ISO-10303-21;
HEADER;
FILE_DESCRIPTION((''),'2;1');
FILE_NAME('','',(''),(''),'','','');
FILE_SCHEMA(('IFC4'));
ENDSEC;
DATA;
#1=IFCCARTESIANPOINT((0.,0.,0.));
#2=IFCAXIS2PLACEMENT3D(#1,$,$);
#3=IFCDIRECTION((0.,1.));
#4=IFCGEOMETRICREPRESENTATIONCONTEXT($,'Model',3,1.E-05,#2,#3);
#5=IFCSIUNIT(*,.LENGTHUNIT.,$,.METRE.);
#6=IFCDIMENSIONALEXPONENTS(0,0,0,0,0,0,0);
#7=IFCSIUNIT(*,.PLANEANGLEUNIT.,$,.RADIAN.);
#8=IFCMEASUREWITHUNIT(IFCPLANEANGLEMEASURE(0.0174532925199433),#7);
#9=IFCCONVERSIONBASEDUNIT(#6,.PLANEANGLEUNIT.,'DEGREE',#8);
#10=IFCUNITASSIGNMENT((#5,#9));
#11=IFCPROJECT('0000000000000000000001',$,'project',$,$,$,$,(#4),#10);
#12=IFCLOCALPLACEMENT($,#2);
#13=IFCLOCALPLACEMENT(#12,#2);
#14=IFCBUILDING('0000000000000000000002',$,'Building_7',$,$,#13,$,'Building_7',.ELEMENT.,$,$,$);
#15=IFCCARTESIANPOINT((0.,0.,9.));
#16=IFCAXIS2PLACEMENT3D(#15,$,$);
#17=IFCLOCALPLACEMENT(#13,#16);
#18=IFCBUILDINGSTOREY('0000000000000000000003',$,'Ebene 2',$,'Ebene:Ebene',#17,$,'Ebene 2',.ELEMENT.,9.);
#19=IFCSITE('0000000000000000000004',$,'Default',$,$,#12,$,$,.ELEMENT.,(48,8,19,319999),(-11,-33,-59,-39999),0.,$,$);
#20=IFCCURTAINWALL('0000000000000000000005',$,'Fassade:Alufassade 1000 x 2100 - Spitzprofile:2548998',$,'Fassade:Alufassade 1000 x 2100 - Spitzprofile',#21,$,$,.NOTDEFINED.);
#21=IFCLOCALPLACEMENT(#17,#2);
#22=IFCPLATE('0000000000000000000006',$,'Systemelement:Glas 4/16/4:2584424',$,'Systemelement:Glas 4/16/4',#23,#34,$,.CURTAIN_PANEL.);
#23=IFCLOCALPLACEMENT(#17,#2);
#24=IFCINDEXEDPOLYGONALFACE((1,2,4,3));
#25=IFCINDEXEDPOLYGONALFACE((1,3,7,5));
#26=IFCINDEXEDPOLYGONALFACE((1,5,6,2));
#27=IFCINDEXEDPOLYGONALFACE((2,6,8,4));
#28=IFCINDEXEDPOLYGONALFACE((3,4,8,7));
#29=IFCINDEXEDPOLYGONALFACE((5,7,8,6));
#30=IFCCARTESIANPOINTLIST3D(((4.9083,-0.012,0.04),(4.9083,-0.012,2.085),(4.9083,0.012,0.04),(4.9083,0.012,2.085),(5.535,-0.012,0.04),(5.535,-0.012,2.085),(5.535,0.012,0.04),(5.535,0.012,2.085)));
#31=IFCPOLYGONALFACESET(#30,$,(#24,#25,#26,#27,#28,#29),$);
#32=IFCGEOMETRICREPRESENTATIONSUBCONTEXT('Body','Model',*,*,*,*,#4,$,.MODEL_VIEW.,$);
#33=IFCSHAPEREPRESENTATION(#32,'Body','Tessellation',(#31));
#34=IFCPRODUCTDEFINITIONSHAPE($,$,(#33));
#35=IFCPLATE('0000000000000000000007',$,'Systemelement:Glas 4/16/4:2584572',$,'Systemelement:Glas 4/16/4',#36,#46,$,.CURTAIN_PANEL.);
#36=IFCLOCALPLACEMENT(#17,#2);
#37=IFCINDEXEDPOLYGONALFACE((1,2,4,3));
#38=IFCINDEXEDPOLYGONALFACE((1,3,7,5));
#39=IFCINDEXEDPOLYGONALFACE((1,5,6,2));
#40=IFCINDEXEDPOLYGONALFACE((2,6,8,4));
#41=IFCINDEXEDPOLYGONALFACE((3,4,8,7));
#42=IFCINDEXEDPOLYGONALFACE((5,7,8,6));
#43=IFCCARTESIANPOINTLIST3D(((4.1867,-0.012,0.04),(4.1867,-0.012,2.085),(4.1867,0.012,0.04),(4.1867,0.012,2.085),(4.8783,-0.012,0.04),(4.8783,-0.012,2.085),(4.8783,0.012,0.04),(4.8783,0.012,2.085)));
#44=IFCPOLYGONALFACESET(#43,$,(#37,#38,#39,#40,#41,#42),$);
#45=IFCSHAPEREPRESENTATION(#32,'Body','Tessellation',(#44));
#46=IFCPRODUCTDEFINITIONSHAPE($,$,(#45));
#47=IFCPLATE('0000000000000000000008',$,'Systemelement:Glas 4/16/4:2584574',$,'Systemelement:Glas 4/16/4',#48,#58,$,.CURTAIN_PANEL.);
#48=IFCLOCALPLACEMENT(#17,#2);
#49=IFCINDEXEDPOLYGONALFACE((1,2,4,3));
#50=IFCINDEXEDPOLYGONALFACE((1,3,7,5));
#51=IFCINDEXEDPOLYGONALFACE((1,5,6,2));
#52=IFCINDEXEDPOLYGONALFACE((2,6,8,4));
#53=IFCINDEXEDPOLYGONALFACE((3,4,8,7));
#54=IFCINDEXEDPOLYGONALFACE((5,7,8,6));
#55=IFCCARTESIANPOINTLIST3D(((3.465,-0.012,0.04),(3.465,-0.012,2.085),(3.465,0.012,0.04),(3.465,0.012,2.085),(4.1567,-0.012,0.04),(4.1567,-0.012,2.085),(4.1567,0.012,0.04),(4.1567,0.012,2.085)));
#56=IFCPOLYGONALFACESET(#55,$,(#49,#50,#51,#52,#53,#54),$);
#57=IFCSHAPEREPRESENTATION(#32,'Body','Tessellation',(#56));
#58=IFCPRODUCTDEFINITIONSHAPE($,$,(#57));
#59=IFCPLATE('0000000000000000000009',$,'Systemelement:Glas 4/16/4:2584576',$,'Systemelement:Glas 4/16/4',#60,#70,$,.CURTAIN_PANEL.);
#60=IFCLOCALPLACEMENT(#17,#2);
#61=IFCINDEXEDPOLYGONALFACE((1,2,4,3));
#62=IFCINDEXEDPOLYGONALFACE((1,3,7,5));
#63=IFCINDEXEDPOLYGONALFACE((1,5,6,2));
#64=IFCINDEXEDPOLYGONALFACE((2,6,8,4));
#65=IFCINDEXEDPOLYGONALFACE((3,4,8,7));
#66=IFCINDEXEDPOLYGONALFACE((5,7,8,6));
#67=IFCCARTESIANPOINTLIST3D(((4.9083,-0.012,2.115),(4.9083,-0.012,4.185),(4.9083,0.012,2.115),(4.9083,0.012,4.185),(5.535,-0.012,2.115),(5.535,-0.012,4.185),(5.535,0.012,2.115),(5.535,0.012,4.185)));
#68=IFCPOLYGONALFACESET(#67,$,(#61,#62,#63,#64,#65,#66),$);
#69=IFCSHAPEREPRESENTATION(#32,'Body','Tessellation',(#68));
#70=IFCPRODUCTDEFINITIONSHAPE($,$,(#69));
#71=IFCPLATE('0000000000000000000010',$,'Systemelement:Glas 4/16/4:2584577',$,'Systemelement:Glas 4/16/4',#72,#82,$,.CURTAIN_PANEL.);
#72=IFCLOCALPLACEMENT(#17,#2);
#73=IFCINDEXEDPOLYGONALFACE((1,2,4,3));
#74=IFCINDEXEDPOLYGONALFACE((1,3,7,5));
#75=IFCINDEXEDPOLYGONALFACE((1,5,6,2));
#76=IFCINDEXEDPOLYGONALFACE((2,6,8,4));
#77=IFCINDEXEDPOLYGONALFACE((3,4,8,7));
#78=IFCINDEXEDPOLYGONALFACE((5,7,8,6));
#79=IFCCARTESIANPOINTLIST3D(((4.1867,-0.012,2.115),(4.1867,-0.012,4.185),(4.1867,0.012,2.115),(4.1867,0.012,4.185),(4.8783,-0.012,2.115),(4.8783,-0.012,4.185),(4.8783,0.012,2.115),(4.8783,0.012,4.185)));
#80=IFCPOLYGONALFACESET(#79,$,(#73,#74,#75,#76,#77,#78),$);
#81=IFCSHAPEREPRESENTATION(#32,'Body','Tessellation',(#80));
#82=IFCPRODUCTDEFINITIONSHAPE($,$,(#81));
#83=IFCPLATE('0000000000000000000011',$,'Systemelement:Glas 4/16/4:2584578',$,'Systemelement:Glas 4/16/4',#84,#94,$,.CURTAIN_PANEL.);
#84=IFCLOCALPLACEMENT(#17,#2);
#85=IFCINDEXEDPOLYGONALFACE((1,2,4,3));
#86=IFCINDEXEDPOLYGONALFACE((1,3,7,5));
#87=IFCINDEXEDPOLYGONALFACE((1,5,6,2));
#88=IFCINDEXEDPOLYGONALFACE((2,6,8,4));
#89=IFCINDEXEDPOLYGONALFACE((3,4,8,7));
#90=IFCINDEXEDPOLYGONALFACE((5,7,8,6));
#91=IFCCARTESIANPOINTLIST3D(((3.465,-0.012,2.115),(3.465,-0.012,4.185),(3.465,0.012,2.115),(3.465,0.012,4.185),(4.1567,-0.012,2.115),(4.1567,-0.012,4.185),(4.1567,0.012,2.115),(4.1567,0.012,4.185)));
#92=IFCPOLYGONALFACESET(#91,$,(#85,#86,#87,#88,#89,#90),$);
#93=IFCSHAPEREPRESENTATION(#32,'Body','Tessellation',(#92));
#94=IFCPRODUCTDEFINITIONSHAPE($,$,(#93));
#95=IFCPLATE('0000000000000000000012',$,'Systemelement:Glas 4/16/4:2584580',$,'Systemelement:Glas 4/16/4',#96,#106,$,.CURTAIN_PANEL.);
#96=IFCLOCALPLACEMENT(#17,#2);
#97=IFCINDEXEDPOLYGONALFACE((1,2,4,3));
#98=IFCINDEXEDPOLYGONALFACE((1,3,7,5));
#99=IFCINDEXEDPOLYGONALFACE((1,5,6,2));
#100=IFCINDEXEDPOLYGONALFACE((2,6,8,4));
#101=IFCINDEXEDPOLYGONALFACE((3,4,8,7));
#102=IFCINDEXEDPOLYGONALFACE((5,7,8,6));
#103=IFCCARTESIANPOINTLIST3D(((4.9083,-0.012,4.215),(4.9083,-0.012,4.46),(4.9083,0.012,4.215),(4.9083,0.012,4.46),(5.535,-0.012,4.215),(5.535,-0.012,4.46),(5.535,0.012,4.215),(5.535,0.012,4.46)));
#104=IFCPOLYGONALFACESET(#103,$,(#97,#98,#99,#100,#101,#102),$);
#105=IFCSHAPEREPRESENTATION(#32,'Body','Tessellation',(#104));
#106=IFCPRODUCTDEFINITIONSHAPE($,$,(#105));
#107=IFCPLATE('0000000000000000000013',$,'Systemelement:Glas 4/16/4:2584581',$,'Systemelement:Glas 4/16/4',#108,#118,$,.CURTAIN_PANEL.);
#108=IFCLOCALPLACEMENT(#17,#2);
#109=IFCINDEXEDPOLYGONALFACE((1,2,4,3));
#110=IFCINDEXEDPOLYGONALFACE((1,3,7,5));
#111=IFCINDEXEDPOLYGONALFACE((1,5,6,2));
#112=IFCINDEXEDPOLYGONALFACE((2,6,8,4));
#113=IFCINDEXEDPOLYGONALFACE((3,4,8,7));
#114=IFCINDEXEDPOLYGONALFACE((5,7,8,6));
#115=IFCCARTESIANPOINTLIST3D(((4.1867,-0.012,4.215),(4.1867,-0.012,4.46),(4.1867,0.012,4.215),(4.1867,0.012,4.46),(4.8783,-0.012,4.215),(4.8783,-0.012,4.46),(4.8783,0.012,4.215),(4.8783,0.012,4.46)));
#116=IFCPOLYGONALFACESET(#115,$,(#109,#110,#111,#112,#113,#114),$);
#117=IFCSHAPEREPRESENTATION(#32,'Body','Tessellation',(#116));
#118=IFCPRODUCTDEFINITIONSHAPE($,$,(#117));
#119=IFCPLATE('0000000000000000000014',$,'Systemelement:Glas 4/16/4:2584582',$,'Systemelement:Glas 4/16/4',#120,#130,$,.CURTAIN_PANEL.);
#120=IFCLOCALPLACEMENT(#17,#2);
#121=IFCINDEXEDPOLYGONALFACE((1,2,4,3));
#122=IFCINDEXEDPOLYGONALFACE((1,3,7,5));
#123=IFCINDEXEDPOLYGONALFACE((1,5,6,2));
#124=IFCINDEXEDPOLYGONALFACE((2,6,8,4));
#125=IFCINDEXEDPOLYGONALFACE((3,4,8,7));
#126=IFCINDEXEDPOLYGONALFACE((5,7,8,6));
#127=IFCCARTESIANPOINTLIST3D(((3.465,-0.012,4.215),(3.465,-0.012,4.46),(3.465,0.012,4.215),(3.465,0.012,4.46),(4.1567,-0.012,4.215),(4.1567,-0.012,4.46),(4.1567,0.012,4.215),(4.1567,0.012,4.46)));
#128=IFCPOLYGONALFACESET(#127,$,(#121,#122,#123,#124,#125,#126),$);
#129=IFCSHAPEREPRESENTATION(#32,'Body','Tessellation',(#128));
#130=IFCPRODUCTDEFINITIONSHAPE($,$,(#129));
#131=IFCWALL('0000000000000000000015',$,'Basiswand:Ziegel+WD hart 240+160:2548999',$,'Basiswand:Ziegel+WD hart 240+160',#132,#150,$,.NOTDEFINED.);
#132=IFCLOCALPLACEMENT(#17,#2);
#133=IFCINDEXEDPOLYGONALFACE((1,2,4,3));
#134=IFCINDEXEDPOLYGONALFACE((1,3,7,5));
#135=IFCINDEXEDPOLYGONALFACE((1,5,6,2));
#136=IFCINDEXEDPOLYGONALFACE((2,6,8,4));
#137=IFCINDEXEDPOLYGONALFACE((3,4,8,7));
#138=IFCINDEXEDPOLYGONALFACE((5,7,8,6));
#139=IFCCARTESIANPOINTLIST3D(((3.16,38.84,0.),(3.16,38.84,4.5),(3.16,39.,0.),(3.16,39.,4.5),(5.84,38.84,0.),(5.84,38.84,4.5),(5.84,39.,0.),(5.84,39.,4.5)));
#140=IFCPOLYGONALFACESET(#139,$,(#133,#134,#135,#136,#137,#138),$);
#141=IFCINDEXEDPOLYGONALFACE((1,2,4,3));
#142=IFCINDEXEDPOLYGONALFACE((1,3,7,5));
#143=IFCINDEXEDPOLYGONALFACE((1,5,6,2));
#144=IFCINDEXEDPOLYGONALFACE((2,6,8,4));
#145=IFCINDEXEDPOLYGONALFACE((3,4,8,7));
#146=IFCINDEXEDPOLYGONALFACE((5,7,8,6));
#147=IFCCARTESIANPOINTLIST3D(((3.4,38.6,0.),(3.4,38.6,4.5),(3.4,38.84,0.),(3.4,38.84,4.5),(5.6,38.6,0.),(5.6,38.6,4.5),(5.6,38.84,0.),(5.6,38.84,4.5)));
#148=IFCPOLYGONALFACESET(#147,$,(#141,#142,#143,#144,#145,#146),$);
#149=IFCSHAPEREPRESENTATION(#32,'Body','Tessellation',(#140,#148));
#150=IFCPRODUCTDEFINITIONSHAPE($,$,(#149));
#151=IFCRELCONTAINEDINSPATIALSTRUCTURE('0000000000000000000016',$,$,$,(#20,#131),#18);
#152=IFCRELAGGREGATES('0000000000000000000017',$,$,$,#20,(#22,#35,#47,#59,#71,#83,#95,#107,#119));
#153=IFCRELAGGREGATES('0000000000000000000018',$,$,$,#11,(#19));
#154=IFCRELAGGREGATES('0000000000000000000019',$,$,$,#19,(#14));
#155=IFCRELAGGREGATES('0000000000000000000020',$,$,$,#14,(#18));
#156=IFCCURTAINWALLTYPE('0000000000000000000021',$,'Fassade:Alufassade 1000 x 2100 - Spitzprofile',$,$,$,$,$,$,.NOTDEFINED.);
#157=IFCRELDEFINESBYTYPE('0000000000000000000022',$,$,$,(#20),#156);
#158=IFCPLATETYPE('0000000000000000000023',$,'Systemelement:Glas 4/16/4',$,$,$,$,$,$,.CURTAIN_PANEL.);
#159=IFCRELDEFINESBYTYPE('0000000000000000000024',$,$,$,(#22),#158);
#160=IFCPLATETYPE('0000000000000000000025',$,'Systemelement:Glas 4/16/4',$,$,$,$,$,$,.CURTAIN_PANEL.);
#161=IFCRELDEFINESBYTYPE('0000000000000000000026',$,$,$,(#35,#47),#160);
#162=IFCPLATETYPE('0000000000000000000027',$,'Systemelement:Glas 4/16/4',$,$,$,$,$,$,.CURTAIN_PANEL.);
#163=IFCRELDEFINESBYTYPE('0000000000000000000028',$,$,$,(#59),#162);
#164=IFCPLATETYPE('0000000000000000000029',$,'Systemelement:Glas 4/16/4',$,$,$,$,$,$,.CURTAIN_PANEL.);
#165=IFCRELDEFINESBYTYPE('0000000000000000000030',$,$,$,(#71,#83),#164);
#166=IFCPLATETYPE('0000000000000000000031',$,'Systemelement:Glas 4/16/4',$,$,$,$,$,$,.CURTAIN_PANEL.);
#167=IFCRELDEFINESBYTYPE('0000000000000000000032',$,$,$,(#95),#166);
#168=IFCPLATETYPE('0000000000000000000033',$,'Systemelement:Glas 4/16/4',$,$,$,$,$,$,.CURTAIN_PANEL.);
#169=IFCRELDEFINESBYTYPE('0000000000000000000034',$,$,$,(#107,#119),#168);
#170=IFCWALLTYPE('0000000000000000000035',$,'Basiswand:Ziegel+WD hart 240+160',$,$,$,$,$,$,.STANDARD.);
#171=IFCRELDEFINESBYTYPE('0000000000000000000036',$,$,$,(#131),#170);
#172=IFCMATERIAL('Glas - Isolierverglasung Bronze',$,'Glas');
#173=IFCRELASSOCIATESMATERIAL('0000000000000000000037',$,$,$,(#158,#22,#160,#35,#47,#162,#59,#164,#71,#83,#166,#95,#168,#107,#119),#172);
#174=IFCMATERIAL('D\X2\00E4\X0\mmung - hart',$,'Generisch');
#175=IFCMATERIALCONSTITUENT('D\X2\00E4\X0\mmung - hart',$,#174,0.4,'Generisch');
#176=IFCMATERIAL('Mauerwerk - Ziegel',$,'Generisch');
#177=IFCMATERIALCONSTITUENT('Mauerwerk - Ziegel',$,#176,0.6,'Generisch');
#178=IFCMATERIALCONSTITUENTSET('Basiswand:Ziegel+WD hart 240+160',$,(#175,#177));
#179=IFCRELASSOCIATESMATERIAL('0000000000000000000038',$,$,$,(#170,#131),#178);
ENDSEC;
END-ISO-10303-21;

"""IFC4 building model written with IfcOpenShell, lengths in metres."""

from ifc_helpers import new_model, entity, si_unit, converted_unit, direction, frame, origin, place, context, subcontext, project, spatial, indexed_curve, outline, extrude, source, transform, mapped, material, constituent, constituent_set, type_object, type_shapes, element, aggregate, save


model = new_model("IFC4")

# Units and contexts
model_context = context("Model", 3, precision=1e-05, world=origin(), true_north=direction((0.0, 1.0)))
body_context = subcontext(model_context, "Body", "Model", "MODEL_VIEW")
ifc_project = project(units=[si_unit("LENGTHUNIT", "METRE"), converted_unit("PLANEANGLEUNIT", "DEGREE", entity("IfcPlaneAngleMeasure", 0.0174532925199433), si_unit("PLANEANGLEUNIT", "RADIAN"), dimensions=[0, 0, 0, 0, 0, 0, 0])], contexts=[model_context])

# Site, building, storey
site_placement = place(None, origin())
site = spatial("IfcSite", under=ifc_project, at=site_placement, Name="Default", CompositionType="ELEMENT", RefLatitude=(48, 8, 19, 319999), RefLongitude=(-11, -33, -59, -39999), RefElevation=0.0)
building_placement = place(site_placement, origin())
building = spatial("IfcBuilding", under=site, at=building_placement, Name="Building_7", LongName="Building_7", CompositionType="ELEMENT")
storey_placement = place(building_placement, frame((0.0, 0.0, 9.0)))
storey = spatial("IfcBuildingStorey", under=building, at=storey_placement, Name="Ebene 2", ObjectType="Ebene:Ebene", LongName="Ebene 2", CompositionType="ELEMENT", Elevation=9.0)

# Curtain wall
curtain_wall_type = type_object("IfcCurtainWallType", Name="Fassade:Alufassade 1000 x 2100 - Spitzprofile", PredefinedType="NOTDEFINED")
curtain_wall_placement = place(storey_placement, frame((0.0, 0.0, -9.0)))
curtain_wall = element("IfcCurtainWall", 1, at=curtain_wall_placement, inside=storey, type_object=curtain_wall_type, Name="Fassade:Alufassade 1000 x 2100 - Spitzprofile:2548998", ObjectType="Fassade:Alufassade 1000 x 2100 - Spitzprofile", PredefinedType="NOTDEFINED")

# Plates
ifc_material_1 = material(Name="Glas - Isolierverglasung Bronze", Category="Glas")
plate_type_1 = type_object("IfcPlateType", Name="Systemelement:Glas 4/16/4", PredefinedType="CURTAIN_PANEL", material=ifc_material_1)
shared_shape_1 = source(origin(), body_context, "Body", "SweptSolid", [
    extrude(outline(indexed_curve([(-0.012, -0.3133), (0.012, -0.3133), (0.012, 0.3133), (-0.012, 0.3133), (-0.012, -0.3133)], self_intersect=False)), frame((0.0, 0.0, 0.0), z_axis=(0.0, 0.0, 1.0), x_axis=(0.0, 1.0, 0.0)), (0.0, 0.0, 1.0), 2.045),
])
type_shapes(plate_type_1, [shared_shape_1])
plate_1_placement = place(curtain_wall_placement, frame((5.2217, 0.0, 9.04), z_axis=(0.0, 0.0, 1.0), x_axis=(-1.0, 0.0, 0.0)))
plate_1 = element("IfcPlate", 2, at=plate_1_placement, type_object=plate_type_1, material=ifc_material_1, Name="Systemelement:Glas 4/16/4:2584424", ObjectType="Systemelement:Glas 4/16/4", PredefinedType="CURTAIN_PANEL", context=body_context, shape_type="MappedRepresentation", body=[
    mapped(shared_shape_1, transform((0.0, 0.0, 0.0), scale=1.0)),
])
plate_type_2 = type_object("IfcPlateType", Name="Systemelement:Glas 4/16/4", PredefinedType="CURTAIN_PANEL", material=ifc_material_1)
shared_shape_2 = source(origin(), body_context, "Body", "SweptSolid", [
    extrude(outline(indexed_curve([(-0.012, -0.3458), (0.012, -0.3458), (0.012, 0.3458), (-0.012, 0.3458), (-0.012, -0.3458)], self_intersect=False)), frame((0.0, 0.0, 0.0), z_axis=(0.0, 0.0, 1.0), x_axis=(0.0, 1.0, 0.0)), (0.0, 0.0, 1.0), 2.045),
])
type_shapes(plate_type_2, [shared_shape_2])
plate_2_placement = place(curtain_wall_placement, frame((4.5325, 0.0, 9.04), z_axis=(0.0, 0.0, 1.0), x_axis=(-1.0, 0.0, 0.0)))
plate_2 = element("IfcPlate", 3, at=plate_2_placement, type_object=plate_type_2, material=ifc_material_1, Name="Systemelement:Glas 4/16/4:2584572", ObjectType="Systemelement:Glas 4/16/4", PredefinedType="CURTAIN_PANEL", context=body_context, shape_type="MappedRepresentation", body=[
    mapped(shared_shape_2, transform((0.0, 0.0, 0.0), scale=1.0)),
])
plate_3_placement = place(curtain_wall_placement, frame((3.8108, 0.0, 9.04), z_axis=(0.0, 0.0, 1.0), x_axis=(-1.0, 0.0, 0.0)))
plate_3 = element("IfcPlate", 4, at=plate_3_placement, type_object=plate_type_2, material=ifc_material_1, Name="Systemelement:Glas 4/16/4:2584574", ObjectType="Systemelement:Glas 4/16/4", PredefinedType="CURTAIN_PANEL", context=body_context, shape_type="MappedRepresentation", body=[
    mapped(shared_shape_2, transform((0.0, 0.0, 0.0), scale=1.0)),
])
plate_type_3 = type_object("IfcPlateType", Name="Systemelement:Glas 4/16/4", PredefinedType="CURTAIN_PANEL", material=ifc_material_1)
shared_shape_3 = source(origin(), body_context, "Body", "SweptSolid", [
    extrude(outline(indexed_curve([(-0.012, -0.3133), (0.012, -0.3133), (0.012, 0.3133), (-0.012, 0.3133), (-0.012, -0.3133)], self_intersect=False)), frame((0.0, 0.0, 0.0), z_axis=(0.0, 0.0, 1.0), x_axis=(0.0, 1.0, 0.0)), (0.0, 0.0, 1.0), 2.07),
])
type_shapes(plate_type_3, [shared_shape_3])
plate_4_placement = place(curtain_wall_placement, frame((5.2217, 0.0, 11.115), z_axis=(0.0, 0.0, 1.0), x_axis=(-1.0, 0.0, 0.0)))
plate_4 = element("IfcPlate", 5, at=plate_4_placement, type_object=plate_type_3, material=ifc_material_1, Name="Systemelement:Glas 4/16/4:2584576", ObjectType="Systemelement:Glas 4/16/4", PredefinedType="CURTAIN_PANEL", context=body_context, shape_type="MappedRepresentation", body=[
    mapped(shared_shape_3, transform((0.0, 0.0, 0.0), scale=1.0)),
])
plate_type_4 = type_object("IfcPlateType", Name="Systemelement:Glas 4/16/4", PredefinedType="CURTAIN_PANEL", material=ifc_material_1)
shared_shape_4 = source(origin(), body_context, "Body", "SweptSolid", [
    extrude(outline(indexed_curve([(-0.012, -0.3458), (0.012, -0.3458), (0.012, 0.3458), (-0.012, 0.3458), (-0.012, -0.3458)], self_intersect=False)), frame((0.0, 0.0, 0.0), z_axis=(0.0, 0.0, 1.0), x_axis=(0.0, 1.0, 0.0)), (0.0, 0.0, 1.0), 2.07),
])
type_shapes(plate_type_4, [shared_shape_4])
plate_5_placement = place(curtain_wall_placement, frame((4.5325, 0.0, 11.115), z_axis=(0.0, 0.0, 1.0), x_axis=(-1.0, 0.0, 0.0)))
plate_5 = element("IfcPlate", 6, at=plate_5_placement, type_object=plate_type_4, material=ifc_material_1, Name="Systemelement:Glas 4/16/4:2584577", ObjectType="Systemelement:Glas 4/16/4", PredefinedType="CURTAIN_PANEL", context=body_context, shape_type="MappedRepresentation", body=[
    mapped(shared_shape_4, transform((0.0, 0.0, 0.0), scale=1.0)),
])
plate_6_placement = place(curtain_wall_placement, frame((3.8108, 0.0, 11.115), z_axis=(0.0, 0.0, 1.0), x_axis=(-1.0, 0.0, 0.0)))
plate_6 = element("IfcPlate", 7, at=plate_6_placement, type_object=plate_type_4, material=ifc_material_1, Name="Systemelement:Glas 4/16/4:2584578", ObjectType="Systemelement:Glas 4/16/4", PredefinedType="CURTAIN_PANEL", context=body_context, shape_type="MappedRepresentation", body=[
    mapped(shared_shape_4, transform((0.0, 0.0, 0.0), scale=1.0)),
])
plate_type_5 = type_object("IfcPlateType", Name="Systemelement:Glas 4/16/4", PredefinedType="CURTAIN_PANEL", material=ifc_material_1)
shared_shape_5 = source(origin(), body_context, "Body", "SweptSolid", [
    extrude(outline(indexed_curve([(-0.012, -0.3133), (0.012, -0.3133), (0.012, 0.3133), (-0.012, 0.3133), (-0.012, -0.3133)], self_intersect=False)), frame((0.0, 0.0, 0.0), z_axis=(0.0, 0.0, 1.0), x_axis=(0.0, 1.0, 0.0)), (0.0, 0.0, 1.0), 0.245),
])
type_shapes(plate_type_5, [shared_shape_5])
plate_7_placement = place(curtain_wall_placement, frame((5.2217, 0.0, 13.215), z_axis=(0.0, 0.0, 1.0), x_axis=(-1.0, 0.0, 0.0)))
plate_7 = element("IfcPlate", 8, at=plate_7_placement, type_object=plate_type_5, material=ifc_material_1, Name="Systemelement:Glas 4/16/4:2584580", ObjectType="Systemelement:Glas 4/16/4", PredefinedType="CURTAIN_PANEL", context=body_context, shape_type="MappedRepresentation", body=[
    mapped(shared_shape_5, transform((0.0, 0.0, 0.0), scale=1.0)),
])
plate_type_6 = type_object("IfcPlateType", Name="Systemelement:Glas 4/16/4", PredefinedType="CURTAIN_PANEL", material=ifc_material_1)
shared_shape_6 = source(origin(), body_context, "Body", "SweptSolid", [
    extrude(outline(indexed_curve([(-0.012, -0.3458), (0.012, -0.3458), (0.012, 0.3458), (-0.012, 0.3458), (-0.012, -0.3458)], self_intersect=False)), frame((0.0, 0.0, 0.0), z_axis=(0.0, 0.0, 1.0), x_axis=(0.0, 1.0, 0.0)), (0.0, 0.0, 1.0), 0.245),
])
type_shapes(plate_type_6, [shared_shape_6])
plate_8_placement = place(curtain_wall_placement, frame((4.5325, 0.0, 13.215), z_axis=(0.0, 0.0, 1.0), x_axis=(-1.0, 0.0, 0.0)))
plate_8 = element("IfcPlate", 9, at=plate_8_placement, type_object=plate_type_6, material=ifc_material_1, Name="Systemelement:Glas 4/16/4:2584581", ObjectType="Systemelement:Glas 4/16/4", PredefinedType="CURTAIN_PANEL", context=body_context, shape_type="MappedRepresentation", body=[
    mapped(shared_shape_6, transform((0.0, 0.0, 0.0), scale=1.0)),
])
plate_9_placement = place(curtain_wall_placement, frame((3.8108, 0.0, 13.215), z_axis=(0.0, 0.0, 1.0), x_axis=(-1.0, 0.0, 0.0)))
plate_9 = element("IfcPlate", 10, at=plate_9_placement, type_object=plate_type_6, material=ifc_material_1, Name="Systemelement:Glas 4/16/4:2584582", ObjectType="Systemelement:Glas 4/16/4", PredefinedType="CURTAIN_PANEL", context=body_context, shape_type="MappedRepresentation", body=[
    mapped(shared_shape_6, transform((0.0, 0.0, 0.0), scale=1.0)),
])
aggregate(curtain_wall, [plate_1, plate_2, plate_3, plate_4, plate_5, plate_6, plate_7, plate_8, plate_9])

# Wall
ifc_material_2 = material(Name="Dämmung - hart", Category="Generisch")
ifc_constituent_1 = constituent(ifc_material_2, Name="Dämmung - hart", Category="Generisch", fraction=0.4)
ifc_material_3 = material(Name="Mauerwerk - Ziegel", Category="Generisch")
ifc_constituent_2 = constituent(ifc_material_3, Name="Mauerwerk - Ziegel", Category="Generisch", fraction=0.6)
ifc_constituent_set = constituent_set(constituents=[ifc_constituent_1, ifc_constituent_2], Name="Basiswand:Ziegel+WD hart 240+160")
wall_type = type_object("IfcWallType", Name="Basiswand:Ziegel+WD hart 240+160", PredefinedType="STANDARD", material=ifc_constituent_set)
wall_placement = place(storey_placement, frame((3.4, 38.8, 0.0)))
element("IfcWall", 11, at=wall_placement, inside=storey, type_object=wall_type, material=ifc_constituent_set, Name="Basiswand:Ziegel+WD hart 240+160:2548999", ObjectType="Basiswand:Ziegel+WD hart 240+160", PredefinedType="NOTDEFINED", context=body_context, shape_type="SweptSolid", body=[
    extrude(outline(indexed_curve([(-0.08, -1.34), (0.08, -1.34), (0.08, 1.34), (-0.08, 1.34), (-0.08, -1.34)], self_intersect=False)), frame((1.1, 0.12, 0.0), z_axis=(0.0, 0.0, 1.0), x_axis=(0.0, -1.0, 0.0)), (0.0, 0.0, 1.0), 4.5),
    extrude(outline(indexed_curve([(-0.12, -1.1), (0.12, -1.1), (0.12, 1.1), (-0.12, 1.1), (-0.12, -1.1)], self_intersect=False)), frame((1.1, -0.08, 0.0), z_axis=(0.0, 0.0, 1.0), x_axis=(0.0, 1.0, 0.0)), (0.0, 0.0, 1.0), 4.5),
])

save(model, "model.ifc")
